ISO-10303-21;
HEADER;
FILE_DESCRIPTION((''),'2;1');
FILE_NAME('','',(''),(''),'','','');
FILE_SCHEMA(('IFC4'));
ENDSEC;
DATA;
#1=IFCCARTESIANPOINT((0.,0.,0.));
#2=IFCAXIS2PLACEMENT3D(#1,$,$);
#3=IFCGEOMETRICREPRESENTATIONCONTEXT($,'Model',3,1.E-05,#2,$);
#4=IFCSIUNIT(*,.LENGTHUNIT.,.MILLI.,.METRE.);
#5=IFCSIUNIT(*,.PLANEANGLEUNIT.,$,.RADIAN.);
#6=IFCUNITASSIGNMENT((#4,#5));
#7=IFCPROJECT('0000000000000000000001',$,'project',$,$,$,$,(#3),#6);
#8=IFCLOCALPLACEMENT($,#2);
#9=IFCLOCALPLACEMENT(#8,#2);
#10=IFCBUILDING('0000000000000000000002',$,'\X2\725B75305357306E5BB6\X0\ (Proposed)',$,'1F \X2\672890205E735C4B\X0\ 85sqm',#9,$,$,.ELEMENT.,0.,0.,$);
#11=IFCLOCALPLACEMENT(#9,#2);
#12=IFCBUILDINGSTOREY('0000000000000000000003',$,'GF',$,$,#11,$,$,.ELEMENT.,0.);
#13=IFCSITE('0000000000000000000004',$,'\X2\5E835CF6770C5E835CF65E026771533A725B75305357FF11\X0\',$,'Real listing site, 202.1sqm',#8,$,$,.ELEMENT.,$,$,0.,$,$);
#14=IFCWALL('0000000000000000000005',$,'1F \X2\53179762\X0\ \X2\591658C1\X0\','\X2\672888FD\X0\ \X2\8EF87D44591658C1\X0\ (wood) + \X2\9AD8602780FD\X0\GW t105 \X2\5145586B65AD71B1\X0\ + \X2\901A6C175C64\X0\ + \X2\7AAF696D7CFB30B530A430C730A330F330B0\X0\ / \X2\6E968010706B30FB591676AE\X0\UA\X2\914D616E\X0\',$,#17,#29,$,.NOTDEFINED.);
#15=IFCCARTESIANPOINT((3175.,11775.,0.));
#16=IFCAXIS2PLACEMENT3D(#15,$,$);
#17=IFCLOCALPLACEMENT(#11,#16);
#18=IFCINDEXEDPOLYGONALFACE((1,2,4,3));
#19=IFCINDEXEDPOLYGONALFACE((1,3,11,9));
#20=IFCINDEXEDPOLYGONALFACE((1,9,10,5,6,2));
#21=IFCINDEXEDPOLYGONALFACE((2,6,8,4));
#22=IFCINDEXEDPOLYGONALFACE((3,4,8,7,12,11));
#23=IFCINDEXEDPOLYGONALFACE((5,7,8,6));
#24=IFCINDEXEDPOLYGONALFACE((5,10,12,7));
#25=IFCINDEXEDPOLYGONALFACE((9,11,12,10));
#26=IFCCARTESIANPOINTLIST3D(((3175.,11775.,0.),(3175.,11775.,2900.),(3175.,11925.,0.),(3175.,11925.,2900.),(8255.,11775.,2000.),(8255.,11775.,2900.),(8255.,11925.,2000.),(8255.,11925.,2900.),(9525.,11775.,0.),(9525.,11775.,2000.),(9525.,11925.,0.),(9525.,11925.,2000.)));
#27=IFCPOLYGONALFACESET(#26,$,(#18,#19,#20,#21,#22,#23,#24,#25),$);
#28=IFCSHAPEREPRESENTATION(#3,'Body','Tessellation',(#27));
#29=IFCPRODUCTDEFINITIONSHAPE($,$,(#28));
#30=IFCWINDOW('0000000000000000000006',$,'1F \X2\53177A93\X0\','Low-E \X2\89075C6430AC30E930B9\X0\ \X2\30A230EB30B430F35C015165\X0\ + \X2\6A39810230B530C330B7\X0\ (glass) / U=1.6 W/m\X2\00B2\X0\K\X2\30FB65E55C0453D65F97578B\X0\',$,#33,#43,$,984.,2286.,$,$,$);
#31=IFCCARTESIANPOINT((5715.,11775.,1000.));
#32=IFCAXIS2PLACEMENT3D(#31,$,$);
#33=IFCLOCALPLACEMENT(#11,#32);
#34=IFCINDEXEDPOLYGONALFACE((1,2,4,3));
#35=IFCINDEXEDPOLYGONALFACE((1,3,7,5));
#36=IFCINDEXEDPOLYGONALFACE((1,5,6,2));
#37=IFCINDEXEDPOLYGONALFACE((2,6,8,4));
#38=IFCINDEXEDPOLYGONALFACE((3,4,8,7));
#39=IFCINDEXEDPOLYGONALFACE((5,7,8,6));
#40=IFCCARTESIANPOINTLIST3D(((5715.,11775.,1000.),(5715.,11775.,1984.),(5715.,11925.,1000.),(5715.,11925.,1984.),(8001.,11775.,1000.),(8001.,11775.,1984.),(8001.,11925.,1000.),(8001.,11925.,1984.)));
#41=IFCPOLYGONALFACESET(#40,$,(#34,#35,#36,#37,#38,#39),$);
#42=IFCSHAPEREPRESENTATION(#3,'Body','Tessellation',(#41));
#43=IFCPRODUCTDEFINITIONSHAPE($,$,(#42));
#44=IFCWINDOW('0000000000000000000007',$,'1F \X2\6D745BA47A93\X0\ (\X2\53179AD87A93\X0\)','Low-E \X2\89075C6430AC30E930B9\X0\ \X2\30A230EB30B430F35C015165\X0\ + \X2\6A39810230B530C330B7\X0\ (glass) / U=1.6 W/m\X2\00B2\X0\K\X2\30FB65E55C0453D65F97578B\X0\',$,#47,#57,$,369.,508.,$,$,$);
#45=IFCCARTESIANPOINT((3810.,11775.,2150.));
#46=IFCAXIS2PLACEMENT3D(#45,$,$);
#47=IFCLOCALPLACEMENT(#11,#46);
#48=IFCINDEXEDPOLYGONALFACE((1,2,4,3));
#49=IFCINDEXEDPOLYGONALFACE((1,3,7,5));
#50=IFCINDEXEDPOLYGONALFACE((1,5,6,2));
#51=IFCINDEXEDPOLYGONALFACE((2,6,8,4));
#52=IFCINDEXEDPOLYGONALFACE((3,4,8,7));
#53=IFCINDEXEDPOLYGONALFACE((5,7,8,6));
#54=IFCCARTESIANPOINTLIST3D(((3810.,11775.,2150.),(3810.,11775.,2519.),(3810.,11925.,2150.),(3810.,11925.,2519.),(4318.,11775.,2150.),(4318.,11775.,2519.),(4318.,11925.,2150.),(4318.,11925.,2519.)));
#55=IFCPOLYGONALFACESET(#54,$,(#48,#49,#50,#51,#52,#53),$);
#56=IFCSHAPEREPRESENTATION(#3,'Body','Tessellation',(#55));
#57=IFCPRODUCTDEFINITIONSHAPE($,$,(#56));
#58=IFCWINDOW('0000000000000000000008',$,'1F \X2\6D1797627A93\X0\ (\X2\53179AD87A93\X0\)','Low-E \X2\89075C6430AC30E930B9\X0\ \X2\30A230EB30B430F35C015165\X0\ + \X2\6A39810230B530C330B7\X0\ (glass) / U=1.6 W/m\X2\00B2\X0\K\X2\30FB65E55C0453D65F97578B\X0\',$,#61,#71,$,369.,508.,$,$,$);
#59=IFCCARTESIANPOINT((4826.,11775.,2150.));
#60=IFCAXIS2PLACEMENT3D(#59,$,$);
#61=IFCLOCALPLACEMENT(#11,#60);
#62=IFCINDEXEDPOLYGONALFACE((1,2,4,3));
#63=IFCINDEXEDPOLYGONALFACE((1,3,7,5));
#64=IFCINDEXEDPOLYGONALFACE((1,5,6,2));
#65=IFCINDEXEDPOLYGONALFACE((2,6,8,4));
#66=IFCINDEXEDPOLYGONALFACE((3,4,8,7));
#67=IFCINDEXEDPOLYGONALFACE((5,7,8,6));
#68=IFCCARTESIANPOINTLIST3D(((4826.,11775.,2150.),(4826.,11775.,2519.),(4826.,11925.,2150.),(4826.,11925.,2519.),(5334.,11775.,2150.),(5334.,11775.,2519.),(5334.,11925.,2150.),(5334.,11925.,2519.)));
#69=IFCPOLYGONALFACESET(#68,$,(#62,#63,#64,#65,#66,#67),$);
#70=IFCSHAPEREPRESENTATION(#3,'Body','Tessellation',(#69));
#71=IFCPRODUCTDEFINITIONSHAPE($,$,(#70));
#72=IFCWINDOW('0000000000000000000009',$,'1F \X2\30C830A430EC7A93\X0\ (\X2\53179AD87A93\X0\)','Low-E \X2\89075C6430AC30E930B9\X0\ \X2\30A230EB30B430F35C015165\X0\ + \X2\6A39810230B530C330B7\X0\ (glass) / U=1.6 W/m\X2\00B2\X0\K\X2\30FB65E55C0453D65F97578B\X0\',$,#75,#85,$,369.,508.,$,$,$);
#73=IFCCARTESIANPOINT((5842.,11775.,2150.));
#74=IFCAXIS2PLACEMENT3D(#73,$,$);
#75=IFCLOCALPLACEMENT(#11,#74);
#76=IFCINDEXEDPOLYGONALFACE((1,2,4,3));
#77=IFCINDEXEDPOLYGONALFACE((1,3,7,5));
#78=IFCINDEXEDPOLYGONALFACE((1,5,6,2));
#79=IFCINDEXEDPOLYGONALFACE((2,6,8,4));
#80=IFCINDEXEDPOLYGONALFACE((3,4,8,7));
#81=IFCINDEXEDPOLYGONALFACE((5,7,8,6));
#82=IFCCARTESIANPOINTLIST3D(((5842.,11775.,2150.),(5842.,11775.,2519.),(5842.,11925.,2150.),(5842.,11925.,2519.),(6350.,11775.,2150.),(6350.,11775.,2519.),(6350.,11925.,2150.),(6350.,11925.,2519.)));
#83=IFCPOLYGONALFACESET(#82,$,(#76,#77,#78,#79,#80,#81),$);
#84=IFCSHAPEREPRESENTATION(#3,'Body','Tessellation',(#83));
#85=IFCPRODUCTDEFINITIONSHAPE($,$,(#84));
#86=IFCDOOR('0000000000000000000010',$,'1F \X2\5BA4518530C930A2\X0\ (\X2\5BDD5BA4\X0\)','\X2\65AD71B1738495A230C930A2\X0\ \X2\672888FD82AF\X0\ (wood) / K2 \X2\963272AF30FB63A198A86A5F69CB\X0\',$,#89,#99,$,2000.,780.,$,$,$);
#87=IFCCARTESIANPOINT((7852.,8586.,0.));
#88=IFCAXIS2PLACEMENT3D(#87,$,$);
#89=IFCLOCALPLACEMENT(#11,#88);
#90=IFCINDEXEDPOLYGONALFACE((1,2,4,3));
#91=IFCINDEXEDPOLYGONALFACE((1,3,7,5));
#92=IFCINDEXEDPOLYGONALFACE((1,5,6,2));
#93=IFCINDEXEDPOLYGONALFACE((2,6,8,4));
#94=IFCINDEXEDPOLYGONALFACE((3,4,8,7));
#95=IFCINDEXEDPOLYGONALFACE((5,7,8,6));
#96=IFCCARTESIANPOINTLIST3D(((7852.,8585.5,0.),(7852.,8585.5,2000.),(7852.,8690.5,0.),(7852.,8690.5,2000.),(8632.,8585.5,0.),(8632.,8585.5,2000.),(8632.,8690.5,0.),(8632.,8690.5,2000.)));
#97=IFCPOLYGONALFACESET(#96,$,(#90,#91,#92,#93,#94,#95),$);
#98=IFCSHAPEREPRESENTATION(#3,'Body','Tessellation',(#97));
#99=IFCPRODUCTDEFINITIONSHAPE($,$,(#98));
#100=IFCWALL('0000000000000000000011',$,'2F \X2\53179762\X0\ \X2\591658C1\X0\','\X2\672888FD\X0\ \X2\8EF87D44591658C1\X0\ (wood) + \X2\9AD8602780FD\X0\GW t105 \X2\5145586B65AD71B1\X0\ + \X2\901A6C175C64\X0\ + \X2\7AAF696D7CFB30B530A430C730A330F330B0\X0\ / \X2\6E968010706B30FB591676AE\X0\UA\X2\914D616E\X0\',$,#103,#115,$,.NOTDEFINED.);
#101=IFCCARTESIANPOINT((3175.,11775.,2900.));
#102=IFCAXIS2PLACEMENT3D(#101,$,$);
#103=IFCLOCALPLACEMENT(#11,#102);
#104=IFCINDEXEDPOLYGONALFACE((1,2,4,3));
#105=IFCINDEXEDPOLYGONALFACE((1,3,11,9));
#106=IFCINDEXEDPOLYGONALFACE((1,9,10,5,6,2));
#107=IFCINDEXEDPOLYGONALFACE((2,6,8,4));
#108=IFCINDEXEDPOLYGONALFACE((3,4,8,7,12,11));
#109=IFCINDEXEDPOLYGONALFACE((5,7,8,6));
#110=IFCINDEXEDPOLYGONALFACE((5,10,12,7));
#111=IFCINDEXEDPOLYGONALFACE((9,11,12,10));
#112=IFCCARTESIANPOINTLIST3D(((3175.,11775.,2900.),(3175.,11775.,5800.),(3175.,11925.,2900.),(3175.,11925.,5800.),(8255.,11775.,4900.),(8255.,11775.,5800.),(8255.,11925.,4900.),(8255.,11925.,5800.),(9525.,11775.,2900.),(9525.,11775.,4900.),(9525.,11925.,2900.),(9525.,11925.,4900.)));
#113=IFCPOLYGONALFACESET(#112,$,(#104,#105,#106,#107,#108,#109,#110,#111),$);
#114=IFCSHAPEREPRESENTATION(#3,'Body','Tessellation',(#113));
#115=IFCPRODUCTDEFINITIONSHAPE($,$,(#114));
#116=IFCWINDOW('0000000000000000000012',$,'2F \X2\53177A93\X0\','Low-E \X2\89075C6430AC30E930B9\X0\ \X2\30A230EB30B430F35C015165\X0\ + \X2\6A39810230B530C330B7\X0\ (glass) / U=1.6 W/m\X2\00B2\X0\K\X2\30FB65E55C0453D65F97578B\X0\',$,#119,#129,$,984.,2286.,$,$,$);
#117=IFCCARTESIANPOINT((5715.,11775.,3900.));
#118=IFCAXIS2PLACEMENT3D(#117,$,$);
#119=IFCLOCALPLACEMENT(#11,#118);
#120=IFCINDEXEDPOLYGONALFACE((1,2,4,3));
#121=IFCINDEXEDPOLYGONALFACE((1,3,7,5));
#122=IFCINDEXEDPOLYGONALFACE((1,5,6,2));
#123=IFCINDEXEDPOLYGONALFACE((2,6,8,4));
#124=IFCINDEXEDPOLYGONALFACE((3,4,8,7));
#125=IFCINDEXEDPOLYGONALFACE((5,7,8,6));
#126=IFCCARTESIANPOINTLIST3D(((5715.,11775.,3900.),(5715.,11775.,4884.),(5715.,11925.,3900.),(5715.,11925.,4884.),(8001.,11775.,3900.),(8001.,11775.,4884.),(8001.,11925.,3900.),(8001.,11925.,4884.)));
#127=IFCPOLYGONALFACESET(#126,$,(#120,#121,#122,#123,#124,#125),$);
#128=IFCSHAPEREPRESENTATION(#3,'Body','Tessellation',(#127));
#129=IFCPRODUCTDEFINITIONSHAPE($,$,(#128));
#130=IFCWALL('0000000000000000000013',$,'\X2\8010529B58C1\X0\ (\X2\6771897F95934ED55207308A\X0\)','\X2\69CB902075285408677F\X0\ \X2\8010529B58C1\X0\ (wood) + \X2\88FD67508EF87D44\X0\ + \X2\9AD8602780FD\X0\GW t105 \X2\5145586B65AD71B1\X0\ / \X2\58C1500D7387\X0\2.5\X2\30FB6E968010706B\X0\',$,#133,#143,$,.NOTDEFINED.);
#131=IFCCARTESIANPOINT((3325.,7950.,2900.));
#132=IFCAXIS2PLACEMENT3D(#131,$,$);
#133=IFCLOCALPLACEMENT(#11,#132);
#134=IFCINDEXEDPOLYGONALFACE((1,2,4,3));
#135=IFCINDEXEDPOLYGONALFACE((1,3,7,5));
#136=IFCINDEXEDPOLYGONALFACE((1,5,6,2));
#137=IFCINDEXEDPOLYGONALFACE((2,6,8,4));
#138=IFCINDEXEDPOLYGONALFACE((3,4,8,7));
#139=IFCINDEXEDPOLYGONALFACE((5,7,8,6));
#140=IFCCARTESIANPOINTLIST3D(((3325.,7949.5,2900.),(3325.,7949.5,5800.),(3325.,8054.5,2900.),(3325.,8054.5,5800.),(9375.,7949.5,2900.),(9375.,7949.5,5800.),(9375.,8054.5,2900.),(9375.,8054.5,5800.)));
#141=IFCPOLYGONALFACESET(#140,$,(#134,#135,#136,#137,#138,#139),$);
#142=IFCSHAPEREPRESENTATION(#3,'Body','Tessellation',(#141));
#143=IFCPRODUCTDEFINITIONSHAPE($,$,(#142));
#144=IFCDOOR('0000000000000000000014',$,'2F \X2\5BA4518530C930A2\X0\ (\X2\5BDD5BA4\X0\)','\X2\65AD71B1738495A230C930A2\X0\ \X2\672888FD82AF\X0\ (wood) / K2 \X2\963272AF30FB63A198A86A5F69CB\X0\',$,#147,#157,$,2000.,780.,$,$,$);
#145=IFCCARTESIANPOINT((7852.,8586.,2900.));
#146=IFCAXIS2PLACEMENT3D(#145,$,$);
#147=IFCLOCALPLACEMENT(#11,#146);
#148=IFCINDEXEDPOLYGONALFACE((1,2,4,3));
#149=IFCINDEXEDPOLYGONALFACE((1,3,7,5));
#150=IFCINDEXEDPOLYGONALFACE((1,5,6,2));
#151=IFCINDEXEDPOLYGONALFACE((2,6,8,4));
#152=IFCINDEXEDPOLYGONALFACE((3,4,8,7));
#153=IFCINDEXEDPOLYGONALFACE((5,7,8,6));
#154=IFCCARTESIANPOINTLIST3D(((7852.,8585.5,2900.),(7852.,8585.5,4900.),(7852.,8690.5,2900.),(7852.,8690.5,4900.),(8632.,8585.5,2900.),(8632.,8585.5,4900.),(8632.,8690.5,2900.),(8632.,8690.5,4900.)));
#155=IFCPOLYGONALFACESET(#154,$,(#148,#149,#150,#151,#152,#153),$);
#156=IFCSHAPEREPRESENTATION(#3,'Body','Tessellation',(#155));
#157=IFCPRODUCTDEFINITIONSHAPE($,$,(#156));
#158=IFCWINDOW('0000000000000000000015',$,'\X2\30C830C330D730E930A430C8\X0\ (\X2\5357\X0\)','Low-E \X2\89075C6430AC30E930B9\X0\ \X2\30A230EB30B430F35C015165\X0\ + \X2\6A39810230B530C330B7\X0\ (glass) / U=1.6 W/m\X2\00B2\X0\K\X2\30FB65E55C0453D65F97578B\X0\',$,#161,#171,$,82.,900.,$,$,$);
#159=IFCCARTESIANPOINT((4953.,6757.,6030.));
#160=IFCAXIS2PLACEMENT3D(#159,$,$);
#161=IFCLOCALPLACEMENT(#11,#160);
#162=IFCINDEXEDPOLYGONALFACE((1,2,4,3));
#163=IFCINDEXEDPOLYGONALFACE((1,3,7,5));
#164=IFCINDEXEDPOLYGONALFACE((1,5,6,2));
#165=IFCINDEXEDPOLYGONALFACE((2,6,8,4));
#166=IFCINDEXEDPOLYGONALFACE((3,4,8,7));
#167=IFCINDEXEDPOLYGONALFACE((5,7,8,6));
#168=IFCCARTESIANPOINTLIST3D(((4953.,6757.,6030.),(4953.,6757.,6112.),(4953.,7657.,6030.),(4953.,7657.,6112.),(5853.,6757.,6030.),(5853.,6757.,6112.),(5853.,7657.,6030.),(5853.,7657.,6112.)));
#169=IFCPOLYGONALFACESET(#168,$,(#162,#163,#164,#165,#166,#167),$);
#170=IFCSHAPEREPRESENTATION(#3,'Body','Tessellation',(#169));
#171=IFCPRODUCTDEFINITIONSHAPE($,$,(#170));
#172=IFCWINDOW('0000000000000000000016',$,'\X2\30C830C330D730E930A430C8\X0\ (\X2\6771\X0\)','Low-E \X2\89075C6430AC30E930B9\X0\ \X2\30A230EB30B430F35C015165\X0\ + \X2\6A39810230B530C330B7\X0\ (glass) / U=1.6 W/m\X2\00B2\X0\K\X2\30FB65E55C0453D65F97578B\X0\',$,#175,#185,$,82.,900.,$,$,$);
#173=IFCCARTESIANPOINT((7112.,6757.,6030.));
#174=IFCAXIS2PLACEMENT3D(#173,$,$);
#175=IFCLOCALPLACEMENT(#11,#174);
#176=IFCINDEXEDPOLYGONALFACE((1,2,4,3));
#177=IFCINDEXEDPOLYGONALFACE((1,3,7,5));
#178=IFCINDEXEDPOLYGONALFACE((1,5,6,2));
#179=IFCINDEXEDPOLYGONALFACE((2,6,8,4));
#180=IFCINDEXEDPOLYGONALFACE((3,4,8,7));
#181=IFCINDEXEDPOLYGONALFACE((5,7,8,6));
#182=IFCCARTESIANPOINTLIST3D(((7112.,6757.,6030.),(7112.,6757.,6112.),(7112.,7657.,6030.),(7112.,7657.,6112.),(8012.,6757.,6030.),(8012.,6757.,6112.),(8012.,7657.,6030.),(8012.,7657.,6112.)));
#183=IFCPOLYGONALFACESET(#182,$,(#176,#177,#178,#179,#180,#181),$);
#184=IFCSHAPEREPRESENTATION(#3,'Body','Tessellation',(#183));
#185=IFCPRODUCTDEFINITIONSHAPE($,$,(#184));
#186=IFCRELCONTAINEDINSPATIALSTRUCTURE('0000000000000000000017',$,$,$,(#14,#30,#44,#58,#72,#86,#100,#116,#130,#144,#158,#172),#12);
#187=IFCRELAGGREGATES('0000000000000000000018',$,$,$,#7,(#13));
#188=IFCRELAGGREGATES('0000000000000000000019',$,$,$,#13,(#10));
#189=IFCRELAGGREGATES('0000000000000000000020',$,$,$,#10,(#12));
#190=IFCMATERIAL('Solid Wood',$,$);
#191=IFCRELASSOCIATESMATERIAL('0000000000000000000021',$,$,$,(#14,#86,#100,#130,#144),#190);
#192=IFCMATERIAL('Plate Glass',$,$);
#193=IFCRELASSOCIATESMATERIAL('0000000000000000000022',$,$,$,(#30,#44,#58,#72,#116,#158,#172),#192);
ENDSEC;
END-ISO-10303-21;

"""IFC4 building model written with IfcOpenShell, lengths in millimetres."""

from ifc_helpers import new_model, si_unit, frame, frame_2d, origin, place, context, project, spatial, rectangle, extrude, material, element, fill, save


model = new_model("IFC4")

# Units and contexts
model_context = context("Model", 3, precision=1e-05, world=origin())
ifc_project = project(units=[si_unit("LENGTHUNIT", "METRE", prefix="MILLI"), si_unit("PLANEANGLEUNIT", "RADIAN")], contexts=[model_context])

# Site, building, storey
site_placement = place(None, origin())
site = spatial("IfcSite", under=ifc_project, at=site_placement, Name="広島県広島市東区牛田南１", ObjectType="Real listing site, 202.1sqm", CompositionType="ELEMENT", RefElevation=0.0)
building_placement = place(site_placement, origin())
building = spatial("IfcBuilding", under=site, at=building_placement, Name="牛田南の家 (Proposed)", ObjectType="1F 木造平屋 85sqm", CompositionType="ELEMENT", ElevationOfRefHeight=0.0, ElevationOfTerrain=0.0)
storey_placement = place(building_placement, origin())
storey = spatial("IfcBuildingStorey", under=building, at=storey_placement, Name="GF", CompositionType="ELEMENT", Elevation=0.0)

# Wall, openings, windows
ifc_material_1 = material(Name="Solid Wood")
wall_1_placement = place(storey_placement, frame((3175.0, 11775.0, 0.0)))
wall_1 = element("IfcWall", 1, at=wall_1_placement, inside=storey, material=ifc_material_1, Name="1F 北面 外壁", Description="木製 軸組外壁 (wood) + 高性能GW t105 充填断熱 + 通気層 + 窯業系サイディング / 準耐火・外皮UA配慮", PredefinedType="NOTDEFINED", context=model_context, shape_type="SweptSolid", body=[
    extrude(rectangle(XDim=6350.0, YDim=150.0, at=frame_2d((3175.0, 75.0))), frame((3175.0, 11775.0, 0.0)), (0.0, 0.0, 1.0), 2900.0),
])
opening_1_placement = place(storey_placement, frame((5715.0, 11775.0, 1000.0)))
opening_1 = element("IfcOpeningElement", 2, at=opening_1_placement, cuts=wall_1, PredefinedType="NOTDEFINED", context=model_context, shape_type="SweptSolid", body=[
    extrude(rectangle(XDim=2286.0, YDim=150.0, at=frame_2d((1143.0, 75.0))), frame((5715.0, 11775.0, 1000.0)), (0.0, 0.0, 1.0), 984.0),
])
opening_2_placement = place(storey_placement, frame((3810.0, 11775.0, 2150.0)))
opening_2 = element("IfcOpeningElement", 3, at=opening_2_placement, cuts=wall_1, PredefinedType="NOTDEFINED", context=model_context, shape_type="SweptSolid", body=[
    extrude(rectangle(XDim=508.0, YDim=150.0, at=frame_2d((254.0, 75.0))), frame((3810.0, 11775.0, 2150.0)), (0.0, 0.0, 1.0), 369.0),
])
opening_3_placement = place(storey_placement, frame((4826.0, 11775.0, 2150.0)))
opening_3 = element("IfcOpeningElement", 4, at=opening_3_placement, cuts=wall_1, PredefinedType="NOTDEFINED", context=model_context, shape_type="SweptSolid", body=[
    extrude(rectangle(XDim=508.0, YDim=150.0, at=frame_2d((254.0, 75.0))), frame((4826.0, 11775.0, 2150.0)), (0.0, 0.0, 1.0), 369.0),
])
opening_4_placement = place(storey_placement, frame((5842.0, 11775.0, 2150.0)))
opening_4 = element("IfcOpeningElement", 5, at=opening_4_placement, cuts=wall_1, PredefinedType="NOTDEFINED", context=model_context, shape_type="SweptSolid", body=[
    extrude(rectangle(XDim=508.0, YDim=150.0, at=frame_2d((254.0, 75.0))), frame((5842.0, 11775.0, 2150.0)), (0.0, 0.0, 1.0), 369.0),
])
ifc_material_2 = material(Name="Plate Glass")
window_1_placement = place(storey_placement, frame((5715.0, 11775.0, 1000.0)))
window_1 = element("IfcWindow", 6, at=window_1_placement, inside=storey, material=ifc_material_2, Name="1F 北窓", Description="Low-E 複層ガラス アルゴン封入 + 樹脂サッシ (glass) / U=1.6 W/m²K・日射取得型", OverallHeight=984.0, OverallWidth=2286.0, context=model_context, shape_type="SweptSolid", body=[
    extrude(rectangle(XDim=2286.0, YDim=150.0, at=frame_2d((1143.0, 75.0))), frame((5715.0, 11775.0, 1000.0)), (0.0, 0.0, 1.0), 984.0),
])
fill(opening_1, window_1)
window_2_placement = place(storey_placement, frame((3810.0, 11775.0, 2150.0)))
window_2 = element("IfcWindow", 7, at=window_2_placement, inside=storey, material=ifc_material_2, Name="1F 浴室窓 (北高窓)", Description="Low-E 複層ガラス アルゴン封入 + 樹脂サッシ (glass) / U=1.6 W/m²K・日射取得型", OverallHeight=369.0, OverallWidth=508.0, context=model_context, shape_type="SweptSolid", body=[
    extrude(rectangle(XDim=508.0, YDim=150.0, at=frame_2d((254.0, 75.0))), frame((3810.0, 11775.0, 2150.0)), (0.0, 0.0, 1.0), 369.0),
])
fill(opening_2, window_2)
window_3_placement = place(storey_placement, frame((4826.0, 11775.0, 2150.0)))
window_3 = element("IfcWindow", 8, at=window_3_placement, inside=storey, material=ifc_material_2, Name="1F 洗面窓 (北高窓)", Description="Low-E 複層ガラス アルゴン封入 + 樹脂サッシ (glass) / U=1.6 W/m²K・日射取得型", OverallHeight=369.0, OverallWidth=508.0, context=model_context, shape_type="SweptSolid", body=[
    extrude(rectangle(XDim=508.0, YDim=150.0, at=frame_2d((254.0, 75.0))), frame((4826.0, 11775.0, 2150.0)), (0.0, 0.0, 1.0), 369.0),
])
fill(opening_3, window_3)
window_4_placement = place(storey_placement, frame((5842.0, 11775.0, 2150.0)))
window_4 = element("IfcWindow", 9, at=window_4_placement, inside=storey, material=ifc_material_2, Name="1F トイレ窓 (北高窓)", Description="Low-E 複層ガラス アルゴン封入 + 樹脂サッシ (glass) / U=1.6 W/m²K・日射取得型", OverallHeight=369.0, OverallWidth=508.0, context=model_context, shape_type="SweptSolid", body=[
    extrude(rectangle(XDim=508.0, YDim=150.0, at=frame_2d((254.0, 75.0))), frame((5842.0, 11775.0, 2150.0)), (0.0, 0.0, 1.0), 369.0),
])
fill(opening_4, window_4)

# Door
door_1_placement = place(storey_placement, frame((7852.0, 8586.0, 0.0)))
element("IfcDoor", 10, at=door_1_placement, inside=storey, material=ifc_material_1, Name="1F 室内ドア (寝室)", Description="断熱玄関ドア 木製芯 (wood) / K2 防犯・採風機構", OverallHeight=2000.0, OverallWidth=780.0, context=model_context, shape_type="SweptSolid", body=[
    extrude(rectangle(XDim=780.0, YDim=105.0, at=frame_2d((390.0, 52.0))), frame((7852.0, 8586.0, 0.0)), (0.0, 0.0, 1.0), 2000.0),
])

# Wall, opening, window
wall_2_placement = place(storey_placement, frame((3175.0, 11775.0, 2900.0)))
wall_2 = element("IfcWall", 11, at=wall_2_placement, inside=storey, material=ifc_material_1, Name="2F 北面 外壁", Description="木製 軸組外壁 (wood) + 高性能GW t105 充填断熱 + 通気層 + 窯業系サイディング / 準耐火・外皮UA配慮", PredefinedType="NOTDEFINED", context=model_context, shape_type="SweptSolid", body=[
    extrude(rectangle(XDim=6350.0, YDim=150.0, at=frame_2d((3175.0, 75.0))), frame((3175.0, 11775.0, 2900.0)), (0.0, 0.0, 1.0), 2900.0),
])
opening_5_placement = place(storey_placement, frame((5715.0, 11775.0, 3900.0)))
opening_5 = element("IfcOpeningElement", 12, at=opening_5_placement, cuts=wall_2, PredefinedType="NOTDEFINED", context=model_context, shape_type="SweptSolid", body=[
    extrude(rectangle(XDim=2286.0, YDim=150.0, at=frame_2d((1143.0, 75.0))), frame((5715.0, 11775.0, 3900.0)), (0.0, 0.0, 1.0), 984.0),
])
window_5_placement = place(storey_placement, frame((5715.0, 11775.0, 3900.0)))
window_5 = element("IfcWindow", 13, at=window_5_placement, inside=storey, material=ifc_material_2, Name="2F 北窓", Description="Low-E 複層ガラス アルゴン封入 + 樹脂サッシ (glass) / U=1.6 W/m²K・日射取得型", OverallHeight=984.0, OverallWidth=2286.0, context=model_context, shape_type="SweptSolid", body=[
    extrude(rectangle(XDim=2286.0, YDim=150.0, at=frame_2d((1143.0, 75.0))), frame((5715.0, 11775.0, 3900.0)), (0.0, 0.0, 1.0), 984.0),
])
fill(opening_5, window_5)

# Wall
wall_3_placement = place(storey_placement, frame((3325.0, 7950.0, 2900.0)))
element("IfcWall", 14, at=wall_3_placement, inside=storey, material=ifc_material_1, Name="耐力壁 (東西間仕切り)", Description="構造用合板 耐力壁 (wood) + 製材軸組 + 高性能GW t105 充填断熱 / 壁倍率2.5・準耐火", PredefinedType="NOTDEFINED", context=model_context, shape_type="SweptSolid", body=[
    extrude(rectangle(XDim=6050.0, YDim=105.0, at=frame_2d((3025.0, 52.0))), frame((3325.0, 7950.0, 2900.0)), (0.0, 0.0, 1.0), 2900.0),
])

# Door
door_2_placement = place(storey_placement, frame((7852.0, 8586.0, 2900.0)))
element("IfcDoor", 15, at=door_2_placement, inside=storey, material=ifc_material_1, Name="2F 室内ドア (寝室)", Description="断熱玄関ドア 木製芯 (wood) / K2 防犯・採風機構", OverallHeight=2000.0, OverallWidth=780.0, context=model_context, shape_type="SweptSolid", body=[
    extrude(rectangle(XDim=780.0, YDim=105.0, at=frame_2d((390.0, 52.0))), frame((7852.0, 8586.0, 2900.0)), (0.0, 0.0, 1.0), 2000.0),
])

# Windows
window_6_placement = place(storey_placement, frame((4953.0, 6757.0, 6030.0)))
element("IfcWindow", 16, at=window_6_placement, inside=storey, material=ifc_material_2, Name="トップライト (南)", Description="Low-E 複層ガラス アルゴン封入 + 樹脂サッシ (glass) / U=1.6 W/m²K・日射取得型", OverallHeight=82.0, OverallWidth=900.0, context=model_context, shape_type="SweptSolid", body=[
    extrude(rectangle(XDim=900.0, YDim=900.0, at=frame_2d((450.0, 450.0))), frame((4953.0, 6757.0, 6030.0)), (0.0, 0.0, 1.0), 82.0),
])
window_7_placement = place(storey_placement, frame((7112.0, 6757.0, 6030.0)))
element("IfcWindow", 17, at=window_7_placement, inside=storey, material=ifc_material_2, Name="トップライト (東)", Description="Low-E 複層ガラス アルゴン封入 + 樹脂サッシ (glass) / U=1.6 W/m²K・日射取得型", OverallHeight=82.0, OverallWidth=900.0, context=model_context, shape_type="SweptSolid", body=[
    extrude(rectangle(XDim=900.0, YDim=900.0, at=frame_2d((450.0, 450.0))), frame((7112.0, 6757.0, 6030.0)), (0.0, 0.0, 1.0), 82.0),
])

save(model, "model.ifc")
